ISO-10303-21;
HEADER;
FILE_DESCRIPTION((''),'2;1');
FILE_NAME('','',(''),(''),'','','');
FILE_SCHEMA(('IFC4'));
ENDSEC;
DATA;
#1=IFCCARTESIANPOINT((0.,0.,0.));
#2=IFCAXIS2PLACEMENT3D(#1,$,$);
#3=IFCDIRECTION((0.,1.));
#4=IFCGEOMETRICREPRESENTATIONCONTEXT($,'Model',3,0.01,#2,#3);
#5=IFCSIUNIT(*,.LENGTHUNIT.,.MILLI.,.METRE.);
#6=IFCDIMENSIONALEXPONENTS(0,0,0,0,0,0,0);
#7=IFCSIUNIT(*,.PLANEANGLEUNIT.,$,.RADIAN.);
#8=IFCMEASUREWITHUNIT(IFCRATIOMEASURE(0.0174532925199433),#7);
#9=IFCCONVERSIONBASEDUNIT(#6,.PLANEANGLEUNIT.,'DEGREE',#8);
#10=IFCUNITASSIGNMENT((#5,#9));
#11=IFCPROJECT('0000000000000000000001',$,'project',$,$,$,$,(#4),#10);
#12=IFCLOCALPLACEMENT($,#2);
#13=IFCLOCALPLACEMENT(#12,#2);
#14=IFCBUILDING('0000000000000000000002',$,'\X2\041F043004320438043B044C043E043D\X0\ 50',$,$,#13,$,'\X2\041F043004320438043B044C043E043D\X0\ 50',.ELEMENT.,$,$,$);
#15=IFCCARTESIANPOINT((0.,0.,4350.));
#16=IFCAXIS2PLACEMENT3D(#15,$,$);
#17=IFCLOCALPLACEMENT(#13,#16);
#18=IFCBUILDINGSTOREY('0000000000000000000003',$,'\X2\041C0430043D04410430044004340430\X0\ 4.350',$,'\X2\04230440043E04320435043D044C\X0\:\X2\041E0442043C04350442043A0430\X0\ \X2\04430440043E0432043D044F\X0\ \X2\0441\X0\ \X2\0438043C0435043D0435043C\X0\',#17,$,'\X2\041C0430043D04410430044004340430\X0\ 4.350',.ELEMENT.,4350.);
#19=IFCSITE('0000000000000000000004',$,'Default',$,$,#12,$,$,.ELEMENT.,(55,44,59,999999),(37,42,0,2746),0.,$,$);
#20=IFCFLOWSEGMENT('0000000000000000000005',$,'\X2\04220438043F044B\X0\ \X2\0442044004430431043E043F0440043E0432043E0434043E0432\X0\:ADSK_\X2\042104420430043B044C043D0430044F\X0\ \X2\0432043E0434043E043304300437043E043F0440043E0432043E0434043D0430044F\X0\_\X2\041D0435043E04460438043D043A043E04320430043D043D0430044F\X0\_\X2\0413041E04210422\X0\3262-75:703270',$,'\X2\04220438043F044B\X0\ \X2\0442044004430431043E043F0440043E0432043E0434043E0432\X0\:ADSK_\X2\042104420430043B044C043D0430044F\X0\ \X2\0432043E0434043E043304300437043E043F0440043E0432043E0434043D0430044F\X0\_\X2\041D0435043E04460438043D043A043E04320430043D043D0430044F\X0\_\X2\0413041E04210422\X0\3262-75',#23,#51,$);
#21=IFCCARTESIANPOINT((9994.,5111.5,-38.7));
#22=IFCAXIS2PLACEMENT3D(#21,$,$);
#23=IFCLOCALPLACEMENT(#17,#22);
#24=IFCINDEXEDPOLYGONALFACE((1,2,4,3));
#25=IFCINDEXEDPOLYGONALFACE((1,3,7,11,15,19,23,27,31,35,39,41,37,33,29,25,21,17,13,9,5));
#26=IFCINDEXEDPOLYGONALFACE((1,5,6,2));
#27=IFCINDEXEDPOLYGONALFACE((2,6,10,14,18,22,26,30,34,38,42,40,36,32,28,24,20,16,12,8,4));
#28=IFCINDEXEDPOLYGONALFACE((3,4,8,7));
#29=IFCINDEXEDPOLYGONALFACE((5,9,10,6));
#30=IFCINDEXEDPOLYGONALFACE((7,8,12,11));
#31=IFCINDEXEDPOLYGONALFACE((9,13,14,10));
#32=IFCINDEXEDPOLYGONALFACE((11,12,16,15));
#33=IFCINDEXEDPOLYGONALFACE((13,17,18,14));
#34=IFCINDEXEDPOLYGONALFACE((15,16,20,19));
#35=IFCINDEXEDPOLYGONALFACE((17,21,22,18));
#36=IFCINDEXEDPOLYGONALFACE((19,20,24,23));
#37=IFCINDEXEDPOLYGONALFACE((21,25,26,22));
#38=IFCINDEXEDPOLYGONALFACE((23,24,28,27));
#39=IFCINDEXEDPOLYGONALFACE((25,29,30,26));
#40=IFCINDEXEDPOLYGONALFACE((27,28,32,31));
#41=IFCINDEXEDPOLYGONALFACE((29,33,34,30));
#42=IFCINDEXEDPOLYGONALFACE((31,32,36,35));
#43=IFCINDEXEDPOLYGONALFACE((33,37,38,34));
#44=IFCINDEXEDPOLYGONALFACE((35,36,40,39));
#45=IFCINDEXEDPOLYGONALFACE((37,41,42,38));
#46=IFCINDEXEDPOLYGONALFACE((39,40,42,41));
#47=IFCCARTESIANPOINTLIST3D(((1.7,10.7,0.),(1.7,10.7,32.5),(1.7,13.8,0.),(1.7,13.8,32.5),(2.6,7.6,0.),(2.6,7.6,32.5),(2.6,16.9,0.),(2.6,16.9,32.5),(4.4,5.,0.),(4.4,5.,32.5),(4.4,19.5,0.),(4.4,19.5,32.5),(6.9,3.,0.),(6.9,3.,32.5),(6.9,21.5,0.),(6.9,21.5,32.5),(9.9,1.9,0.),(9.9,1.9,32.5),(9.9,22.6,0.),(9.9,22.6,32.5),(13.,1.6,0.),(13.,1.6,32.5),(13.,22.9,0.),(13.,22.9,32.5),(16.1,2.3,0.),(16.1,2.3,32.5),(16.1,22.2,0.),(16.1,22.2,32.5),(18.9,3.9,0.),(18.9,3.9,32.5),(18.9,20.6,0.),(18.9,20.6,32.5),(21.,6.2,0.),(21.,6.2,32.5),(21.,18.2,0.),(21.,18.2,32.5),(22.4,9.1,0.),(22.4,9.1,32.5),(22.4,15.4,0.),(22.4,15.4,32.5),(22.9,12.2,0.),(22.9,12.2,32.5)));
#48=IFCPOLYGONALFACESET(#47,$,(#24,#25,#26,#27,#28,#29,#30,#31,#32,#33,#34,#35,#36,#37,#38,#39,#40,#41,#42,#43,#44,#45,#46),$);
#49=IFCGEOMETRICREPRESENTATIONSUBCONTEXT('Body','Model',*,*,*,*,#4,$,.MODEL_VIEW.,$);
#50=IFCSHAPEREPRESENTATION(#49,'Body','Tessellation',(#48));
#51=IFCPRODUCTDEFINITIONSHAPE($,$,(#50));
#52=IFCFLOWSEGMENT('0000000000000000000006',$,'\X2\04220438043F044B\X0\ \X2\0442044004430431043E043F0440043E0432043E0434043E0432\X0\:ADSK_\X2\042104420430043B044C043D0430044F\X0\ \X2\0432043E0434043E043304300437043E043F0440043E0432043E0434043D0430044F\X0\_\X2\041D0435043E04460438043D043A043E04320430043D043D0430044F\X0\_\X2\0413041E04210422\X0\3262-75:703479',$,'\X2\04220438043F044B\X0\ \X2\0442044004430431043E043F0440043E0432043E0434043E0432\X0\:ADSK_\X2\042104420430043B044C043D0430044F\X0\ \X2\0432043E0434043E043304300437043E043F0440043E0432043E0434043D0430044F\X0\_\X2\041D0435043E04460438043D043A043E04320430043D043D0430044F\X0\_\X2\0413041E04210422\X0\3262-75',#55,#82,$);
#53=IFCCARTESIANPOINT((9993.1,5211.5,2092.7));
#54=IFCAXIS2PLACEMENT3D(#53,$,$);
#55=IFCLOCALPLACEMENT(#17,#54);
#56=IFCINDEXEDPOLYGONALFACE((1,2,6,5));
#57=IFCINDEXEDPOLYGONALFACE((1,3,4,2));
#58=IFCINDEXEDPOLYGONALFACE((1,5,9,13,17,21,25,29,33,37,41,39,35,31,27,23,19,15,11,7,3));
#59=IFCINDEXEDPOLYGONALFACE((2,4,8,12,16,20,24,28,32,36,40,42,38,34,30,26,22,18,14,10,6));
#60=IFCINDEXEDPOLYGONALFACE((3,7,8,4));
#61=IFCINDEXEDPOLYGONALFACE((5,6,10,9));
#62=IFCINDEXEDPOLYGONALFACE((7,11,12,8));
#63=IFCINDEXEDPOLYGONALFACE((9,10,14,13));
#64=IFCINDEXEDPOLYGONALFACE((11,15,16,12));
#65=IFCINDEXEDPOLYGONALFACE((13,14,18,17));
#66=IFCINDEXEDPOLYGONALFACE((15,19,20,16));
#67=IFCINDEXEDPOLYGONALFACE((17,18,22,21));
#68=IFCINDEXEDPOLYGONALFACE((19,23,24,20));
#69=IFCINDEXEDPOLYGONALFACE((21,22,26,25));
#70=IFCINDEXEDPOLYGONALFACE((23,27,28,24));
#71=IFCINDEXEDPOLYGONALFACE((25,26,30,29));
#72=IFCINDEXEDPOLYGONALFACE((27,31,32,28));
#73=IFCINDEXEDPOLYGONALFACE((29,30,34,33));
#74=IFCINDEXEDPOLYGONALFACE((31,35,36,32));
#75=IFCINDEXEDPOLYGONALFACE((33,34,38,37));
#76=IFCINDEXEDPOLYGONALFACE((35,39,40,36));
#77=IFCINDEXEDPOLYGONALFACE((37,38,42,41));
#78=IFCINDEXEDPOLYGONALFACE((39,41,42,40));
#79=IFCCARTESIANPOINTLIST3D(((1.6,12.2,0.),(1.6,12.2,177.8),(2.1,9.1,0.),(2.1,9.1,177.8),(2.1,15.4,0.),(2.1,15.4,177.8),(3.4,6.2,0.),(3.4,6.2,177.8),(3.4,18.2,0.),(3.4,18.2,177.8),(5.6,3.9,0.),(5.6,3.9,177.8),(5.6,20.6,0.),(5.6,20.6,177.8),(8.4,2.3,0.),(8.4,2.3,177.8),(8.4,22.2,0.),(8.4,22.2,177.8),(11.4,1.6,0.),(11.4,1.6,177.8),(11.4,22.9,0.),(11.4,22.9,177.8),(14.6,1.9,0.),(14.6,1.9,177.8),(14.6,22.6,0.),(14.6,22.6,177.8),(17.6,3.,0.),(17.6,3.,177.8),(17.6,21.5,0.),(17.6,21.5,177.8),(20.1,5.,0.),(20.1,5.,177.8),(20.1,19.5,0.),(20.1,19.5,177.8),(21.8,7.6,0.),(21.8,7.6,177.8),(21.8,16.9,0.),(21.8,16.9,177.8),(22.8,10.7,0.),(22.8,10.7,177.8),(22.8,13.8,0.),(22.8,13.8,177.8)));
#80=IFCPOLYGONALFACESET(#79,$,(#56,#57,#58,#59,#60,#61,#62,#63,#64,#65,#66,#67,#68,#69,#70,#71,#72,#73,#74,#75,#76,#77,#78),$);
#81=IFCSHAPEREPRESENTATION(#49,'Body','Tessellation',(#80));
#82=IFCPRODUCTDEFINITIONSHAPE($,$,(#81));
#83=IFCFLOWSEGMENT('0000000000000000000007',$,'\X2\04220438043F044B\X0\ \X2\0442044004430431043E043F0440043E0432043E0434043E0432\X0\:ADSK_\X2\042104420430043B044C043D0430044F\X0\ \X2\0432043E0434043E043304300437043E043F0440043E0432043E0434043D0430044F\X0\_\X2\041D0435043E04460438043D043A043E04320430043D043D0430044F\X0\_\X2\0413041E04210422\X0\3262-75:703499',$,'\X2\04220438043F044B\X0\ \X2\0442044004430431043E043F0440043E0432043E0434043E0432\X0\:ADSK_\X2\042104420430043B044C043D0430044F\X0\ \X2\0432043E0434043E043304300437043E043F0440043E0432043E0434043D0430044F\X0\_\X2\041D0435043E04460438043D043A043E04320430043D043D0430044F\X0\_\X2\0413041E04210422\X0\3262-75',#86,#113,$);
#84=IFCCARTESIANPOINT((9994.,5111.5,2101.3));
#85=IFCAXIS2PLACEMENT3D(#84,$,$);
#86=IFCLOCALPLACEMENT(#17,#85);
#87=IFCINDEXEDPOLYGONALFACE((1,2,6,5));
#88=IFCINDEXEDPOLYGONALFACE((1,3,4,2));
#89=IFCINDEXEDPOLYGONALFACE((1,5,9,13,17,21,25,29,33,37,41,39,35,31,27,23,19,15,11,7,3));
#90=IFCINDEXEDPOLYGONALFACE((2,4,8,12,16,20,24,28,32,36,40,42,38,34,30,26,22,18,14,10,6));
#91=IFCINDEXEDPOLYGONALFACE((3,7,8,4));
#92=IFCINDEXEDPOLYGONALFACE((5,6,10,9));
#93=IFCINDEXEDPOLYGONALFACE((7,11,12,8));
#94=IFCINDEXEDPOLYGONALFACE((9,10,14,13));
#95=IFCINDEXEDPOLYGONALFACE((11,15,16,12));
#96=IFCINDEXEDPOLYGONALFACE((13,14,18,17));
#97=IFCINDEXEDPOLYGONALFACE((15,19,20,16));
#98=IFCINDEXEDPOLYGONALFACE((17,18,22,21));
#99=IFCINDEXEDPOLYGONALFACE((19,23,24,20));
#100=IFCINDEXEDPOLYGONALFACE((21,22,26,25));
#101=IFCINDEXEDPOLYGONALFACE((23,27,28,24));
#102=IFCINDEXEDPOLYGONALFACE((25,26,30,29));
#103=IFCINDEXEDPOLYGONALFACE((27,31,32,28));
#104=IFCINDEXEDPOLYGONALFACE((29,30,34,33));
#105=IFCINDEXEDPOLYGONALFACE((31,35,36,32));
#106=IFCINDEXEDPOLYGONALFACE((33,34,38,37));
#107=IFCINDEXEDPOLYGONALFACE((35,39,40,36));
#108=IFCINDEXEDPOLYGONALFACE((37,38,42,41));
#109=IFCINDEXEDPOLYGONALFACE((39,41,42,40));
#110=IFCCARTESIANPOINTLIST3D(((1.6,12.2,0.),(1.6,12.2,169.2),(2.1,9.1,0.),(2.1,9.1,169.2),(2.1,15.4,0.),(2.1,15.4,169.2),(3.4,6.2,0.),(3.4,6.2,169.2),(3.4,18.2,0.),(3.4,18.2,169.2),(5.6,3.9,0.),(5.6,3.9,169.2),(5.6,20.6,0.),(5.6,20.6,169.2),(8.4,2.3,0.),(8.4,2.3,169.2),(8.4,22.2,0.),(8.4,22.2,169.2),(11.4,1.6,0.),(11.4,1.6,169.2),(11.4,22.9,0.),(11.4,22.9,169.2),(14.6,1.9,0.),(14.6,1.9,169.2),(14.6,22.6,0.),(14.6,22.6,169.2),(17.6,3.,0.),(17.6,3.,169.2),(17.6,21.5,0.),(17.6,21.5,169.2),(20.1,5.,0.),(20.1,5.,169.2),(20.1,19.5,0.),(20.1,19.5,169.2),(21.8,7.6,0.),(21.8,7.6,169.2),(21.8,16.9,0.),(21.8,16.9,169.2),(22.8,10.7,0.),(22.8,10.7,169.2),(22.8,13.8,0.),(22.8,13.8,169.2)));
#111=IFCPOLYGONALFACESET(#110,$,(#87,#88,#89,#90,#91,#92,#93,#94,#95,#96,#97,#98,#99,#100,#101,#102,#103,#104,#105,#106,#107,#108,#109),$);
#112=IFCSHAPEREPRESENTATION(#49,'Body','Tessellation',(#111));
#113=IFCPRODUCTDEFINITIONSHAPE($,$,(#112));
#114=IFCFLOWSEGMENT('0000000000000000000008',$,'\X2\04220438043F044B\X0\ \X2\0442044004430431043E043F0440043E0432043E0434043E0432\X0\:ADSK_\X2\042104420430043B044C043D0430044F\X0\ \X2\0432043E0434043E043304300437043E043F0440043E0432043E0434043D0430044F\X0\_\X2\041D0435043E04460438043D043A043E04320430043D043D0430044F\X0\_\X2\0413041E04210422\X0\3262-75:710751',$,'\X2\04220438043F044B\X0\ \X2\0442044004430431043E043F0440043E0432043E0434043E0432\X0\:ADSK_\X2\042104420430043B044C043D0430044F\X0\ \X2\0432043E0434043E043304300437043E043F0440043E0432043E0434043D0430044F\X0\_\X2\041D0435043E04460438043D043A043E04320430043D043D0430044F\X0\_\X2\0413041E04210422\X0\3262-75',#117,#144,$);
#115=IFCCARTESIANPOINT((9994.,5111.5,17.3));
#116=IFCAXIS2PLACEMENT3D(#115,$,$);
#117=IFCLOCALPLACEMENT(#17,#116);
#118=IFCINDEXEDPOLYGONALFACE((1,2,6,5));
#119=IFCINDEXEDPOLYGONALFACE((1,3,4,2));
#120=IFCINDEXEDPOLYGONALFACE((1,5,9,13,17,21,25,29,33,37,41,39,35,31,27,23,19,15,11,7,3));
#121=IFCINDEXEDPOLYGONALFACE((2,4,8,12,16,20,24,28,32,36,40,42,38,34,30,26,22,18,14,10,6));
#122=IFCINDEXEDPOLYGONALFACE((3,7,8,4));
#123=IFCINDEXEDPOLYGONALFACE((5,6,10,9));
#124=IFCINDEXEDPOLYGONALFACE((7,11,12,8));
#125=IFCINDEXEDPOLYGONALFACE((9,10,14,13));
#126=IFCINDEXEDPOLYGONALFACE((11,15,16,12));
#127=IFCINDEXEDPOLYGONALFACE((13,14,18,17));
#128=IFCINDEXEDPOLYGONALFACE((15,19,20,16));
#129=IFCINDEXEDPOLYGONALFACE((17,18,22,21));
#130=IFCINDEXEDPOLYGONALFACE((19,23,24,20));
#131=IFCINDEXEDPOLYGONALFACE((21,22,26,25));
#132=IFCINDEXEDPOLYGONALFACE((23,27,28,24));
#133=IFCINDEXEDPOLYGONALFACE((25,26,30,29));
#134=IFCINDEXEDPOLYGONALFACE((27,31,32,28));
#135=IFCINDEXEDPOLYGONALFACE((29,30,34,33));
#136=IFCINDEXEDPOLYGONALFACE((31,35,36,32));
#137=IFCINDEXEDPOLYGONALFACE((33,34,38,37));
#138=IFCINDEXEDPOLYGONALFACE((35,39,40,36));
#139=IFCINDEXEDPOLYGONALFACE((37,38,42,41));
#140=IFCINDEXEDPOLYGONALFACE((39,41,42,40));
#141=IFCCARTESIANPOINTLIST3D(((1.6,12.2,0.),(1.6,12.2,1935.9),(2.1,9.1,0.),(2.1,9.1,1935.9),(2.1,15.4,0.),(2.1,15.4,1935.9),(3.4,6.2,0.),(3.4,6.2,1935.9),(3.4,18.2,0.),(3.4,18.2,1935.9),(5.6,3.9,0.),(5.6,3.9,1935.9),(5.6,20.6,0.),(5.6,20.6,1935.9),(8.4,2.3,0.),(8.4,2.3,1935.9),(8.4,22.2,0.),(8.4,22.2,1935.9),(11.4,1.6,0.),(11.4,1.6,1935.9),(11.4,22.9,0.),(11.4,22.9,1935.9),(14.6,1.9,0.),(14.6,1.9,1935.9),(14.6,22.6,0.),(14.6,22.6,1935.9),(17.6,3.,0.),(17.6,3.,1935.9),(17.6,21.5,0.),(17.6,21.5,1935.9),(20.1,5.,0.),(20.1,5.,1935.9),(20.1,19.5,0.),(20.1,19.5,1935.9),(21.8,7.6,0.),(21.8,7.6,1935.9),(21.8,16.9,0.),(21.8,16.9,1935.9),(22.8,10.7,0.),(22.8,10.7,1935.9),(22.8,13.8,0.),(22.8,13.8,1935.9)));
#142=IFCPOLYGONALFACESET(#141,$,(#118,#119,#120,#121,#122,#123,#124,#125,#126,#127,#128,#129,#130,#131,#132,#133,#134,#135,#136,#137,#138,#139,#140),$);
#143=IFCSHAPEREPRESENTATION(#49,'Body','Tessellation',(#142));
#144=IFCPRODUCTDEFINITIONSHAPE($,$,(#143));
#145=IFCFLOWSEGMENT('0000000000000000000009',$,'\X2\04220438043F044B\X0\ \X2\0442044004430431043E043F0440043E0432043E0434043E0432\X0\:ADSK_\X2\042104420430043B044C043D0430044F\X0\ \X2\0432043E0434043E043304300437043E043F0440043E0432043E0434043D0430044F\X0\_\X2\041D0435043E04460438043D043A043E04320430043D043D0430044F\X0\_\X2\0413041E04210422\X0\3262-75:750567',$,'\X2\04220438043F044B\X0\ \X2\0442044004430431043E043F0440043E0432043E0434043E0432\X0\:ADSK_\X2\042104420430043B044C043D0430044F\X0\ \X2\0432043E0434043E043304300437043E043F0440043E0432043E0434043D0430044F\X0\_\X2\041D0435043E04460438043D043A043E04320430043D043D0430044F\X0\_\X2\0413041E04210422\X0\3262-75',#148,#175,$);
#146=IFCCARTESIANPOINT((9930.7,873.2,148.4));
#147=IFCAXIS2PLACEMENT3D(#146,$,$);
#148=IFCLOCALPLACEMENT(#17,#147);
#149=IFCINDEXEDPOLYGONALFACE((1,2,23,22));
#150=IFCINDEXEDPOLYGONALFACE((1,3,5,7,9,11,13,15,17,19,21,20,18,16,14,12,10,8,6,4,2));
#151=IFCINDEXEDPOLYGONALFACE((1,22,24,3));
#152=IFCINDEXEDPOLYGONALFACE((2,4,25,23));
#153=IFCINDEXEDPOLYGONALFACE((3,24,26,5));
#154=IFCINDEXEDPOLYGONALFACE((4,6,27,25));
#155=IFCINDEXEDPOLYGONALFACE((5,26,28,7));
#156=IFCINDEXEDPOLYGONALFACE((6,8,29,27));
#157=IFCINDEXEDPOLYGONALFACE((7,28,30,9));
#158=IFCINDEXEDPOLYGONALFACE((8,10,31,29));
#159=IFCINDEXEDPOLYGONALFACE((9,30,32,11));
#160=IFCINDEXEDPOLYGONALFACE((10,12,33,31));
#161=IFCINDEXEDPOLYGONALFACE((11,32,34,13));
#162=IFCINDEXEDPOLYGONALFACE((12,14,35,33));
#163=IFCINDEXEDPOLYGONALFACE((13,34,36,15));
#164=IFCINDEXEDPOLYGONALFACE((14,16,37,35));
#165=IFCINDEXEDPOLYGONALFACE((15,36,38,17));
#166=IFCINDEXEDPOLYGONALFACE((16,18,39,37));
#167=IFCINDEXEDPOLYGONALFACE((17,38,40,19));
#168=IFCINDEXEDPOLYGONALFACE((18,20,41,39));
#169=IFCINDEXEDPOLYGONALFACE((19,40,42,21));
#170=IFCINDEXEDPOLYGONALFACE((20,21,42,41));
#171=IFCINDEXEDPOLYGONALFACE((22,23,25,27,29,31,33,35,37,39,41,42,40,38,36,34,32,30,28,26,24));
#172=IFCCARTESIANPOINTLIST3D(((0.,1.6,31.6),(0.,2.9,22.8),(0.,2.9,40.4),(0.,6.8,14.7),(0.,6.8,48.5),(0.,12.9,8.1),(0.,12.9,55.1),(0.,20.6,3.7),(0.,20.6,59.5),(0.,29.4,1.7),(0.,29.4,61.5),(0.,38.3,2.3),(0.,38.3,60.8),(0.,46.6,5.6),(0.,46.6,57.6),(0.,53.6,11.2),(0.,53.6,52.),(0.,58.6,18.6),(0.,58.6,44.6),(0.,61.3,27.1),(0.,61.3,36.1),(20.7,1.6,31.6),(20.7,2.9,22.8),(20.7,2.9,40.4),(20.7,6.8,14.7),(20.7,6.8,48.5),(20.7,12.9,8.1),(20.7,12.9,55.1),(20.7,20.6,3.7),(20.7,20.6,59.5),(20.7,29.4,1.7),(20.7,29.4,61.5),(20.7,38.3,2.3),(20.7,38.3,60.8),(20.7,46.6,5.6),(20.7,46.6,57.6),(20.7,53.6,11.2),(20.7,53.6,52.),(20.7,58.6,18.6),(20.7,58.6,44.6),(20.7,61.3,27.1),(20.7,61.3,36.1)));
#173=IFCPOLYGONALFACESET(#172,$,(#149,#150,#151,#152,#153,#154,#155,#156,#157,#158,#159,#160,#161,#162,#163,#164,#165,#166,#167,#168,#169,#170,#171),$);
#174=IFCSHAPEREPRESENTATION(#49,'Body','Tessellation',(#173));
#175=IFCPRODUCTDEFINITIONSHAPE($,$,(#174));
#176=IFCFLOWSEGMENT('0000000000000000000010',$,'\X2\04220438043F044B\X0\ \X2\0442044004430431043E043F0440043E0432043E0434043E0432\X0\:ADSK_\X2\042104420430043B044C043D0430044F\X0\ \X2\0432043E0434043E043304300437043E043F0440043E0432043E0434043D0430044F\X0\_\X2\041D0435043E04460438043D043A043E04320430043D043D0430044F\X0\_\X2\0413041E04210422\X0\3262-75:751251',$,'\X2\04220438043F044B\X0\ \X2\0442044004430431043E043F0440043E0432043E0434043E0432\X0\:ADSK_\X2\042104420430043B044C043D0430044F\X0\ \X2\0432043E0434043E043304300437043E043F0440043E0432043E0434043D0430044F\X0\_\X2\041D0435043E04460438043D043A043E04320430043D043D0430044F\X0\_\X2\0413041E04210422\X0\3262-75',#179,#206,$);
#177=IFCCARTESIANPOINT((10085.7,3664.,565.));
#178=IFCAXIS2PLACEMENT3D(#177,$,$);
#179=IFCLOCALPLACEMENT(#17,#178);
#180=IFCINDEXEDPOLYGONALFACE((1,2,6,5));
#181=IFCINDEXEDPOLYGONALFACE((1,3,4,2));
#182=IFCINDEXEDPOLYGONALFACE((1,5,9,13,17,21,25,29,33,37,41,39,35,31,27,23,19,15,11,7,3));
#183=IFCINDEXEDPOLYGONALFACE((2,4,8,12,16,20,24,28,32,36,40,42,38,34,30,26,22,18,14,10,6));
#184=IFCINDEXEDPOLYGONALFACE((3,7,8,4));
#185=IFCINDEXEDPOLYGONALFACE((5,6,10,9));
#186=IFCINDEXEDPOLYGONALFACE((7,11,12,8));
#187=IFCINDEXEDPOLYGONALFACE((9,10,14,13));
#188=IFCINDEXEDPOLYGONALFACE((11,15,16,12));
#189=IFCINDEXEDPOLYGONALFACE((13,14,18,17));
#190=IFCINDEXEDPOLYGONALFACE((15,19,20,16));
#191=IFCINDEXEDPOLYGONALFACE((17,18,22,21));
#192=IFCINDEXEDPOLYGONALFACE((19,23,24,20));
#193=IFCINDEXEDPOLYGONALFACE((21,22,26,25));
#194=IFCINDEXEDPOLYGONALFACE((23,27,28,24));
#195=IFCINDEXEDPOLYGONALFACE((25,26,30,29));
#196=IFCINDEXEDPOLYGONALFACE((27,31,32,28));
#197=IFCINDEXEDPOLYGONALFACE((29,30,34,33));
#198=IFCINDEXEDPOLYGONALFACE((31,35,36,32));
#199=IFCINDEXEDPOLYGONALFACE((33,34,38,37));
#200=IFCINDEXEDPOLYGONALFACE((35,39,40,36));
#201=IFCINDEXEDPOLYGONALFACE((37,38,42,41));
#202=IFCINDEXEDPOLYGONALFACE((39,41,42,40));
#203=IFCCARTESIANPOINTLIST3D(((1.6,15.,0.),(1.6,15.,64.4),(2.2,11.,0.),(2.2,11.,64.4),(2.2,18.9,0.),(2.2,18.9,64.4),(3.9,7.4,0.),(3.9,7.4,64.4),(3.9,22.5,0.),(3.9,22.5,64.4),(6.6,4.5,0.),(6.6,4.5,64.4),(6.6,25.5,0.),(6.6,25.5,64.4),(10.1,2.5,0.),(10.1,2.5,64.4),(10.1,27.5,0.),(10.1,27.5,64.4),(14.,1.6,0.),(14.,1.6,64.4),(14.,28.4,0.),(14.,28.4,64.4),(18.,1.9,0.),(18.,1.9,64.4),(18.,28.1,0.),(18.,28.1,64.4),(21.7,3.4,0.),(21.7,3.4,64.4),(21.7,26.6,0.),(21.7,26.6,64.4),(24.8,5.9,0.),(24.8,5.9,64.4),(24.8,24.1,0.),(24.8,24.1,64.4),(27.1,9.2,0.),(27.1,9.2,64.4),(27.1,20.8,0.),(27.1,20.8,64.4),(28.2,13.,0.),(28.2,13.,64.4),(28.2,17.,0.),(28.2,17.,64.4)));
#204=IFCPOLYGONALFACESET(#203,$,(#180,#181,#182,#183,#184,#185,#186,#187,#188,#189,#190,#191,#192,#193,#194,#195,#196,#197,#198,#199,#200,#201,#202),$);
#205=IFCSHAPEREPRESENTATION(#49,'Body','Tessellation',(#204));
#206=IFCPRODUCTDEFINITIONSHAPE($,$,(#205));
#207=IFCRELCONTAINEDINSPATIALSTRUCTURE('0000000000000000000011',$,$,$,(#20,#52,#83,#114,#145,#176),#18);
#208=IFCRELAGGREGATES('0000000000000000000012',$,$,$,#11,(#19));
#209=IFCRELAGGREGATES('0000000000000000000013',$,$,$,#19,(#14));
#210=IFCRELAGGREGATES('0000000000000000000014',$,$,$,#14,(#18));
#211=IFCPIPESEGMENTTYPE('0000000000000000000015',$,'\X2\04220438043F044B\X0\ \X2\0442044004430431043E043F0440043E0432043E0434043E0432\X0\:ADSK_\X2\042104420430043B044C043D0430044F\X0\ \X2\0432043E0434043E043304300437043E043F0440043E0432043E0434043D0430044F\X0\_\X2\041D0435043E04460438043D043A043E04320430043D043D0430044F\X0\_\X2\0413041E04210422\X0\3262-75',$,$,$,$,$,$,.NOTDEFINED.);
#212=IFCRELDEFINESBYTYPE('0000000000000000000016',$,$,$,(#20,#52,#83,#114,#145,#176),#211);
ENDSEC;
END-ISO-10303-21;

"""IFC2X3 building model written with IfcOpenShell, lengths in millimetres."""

from ifc_helpers import new_model, entity, si_unit, converted_unit, direction, frame, frame_2d, origin, origin_2d_with_axis, place, context, subcontext, project, spatial, circle, extrude, type_object, element, save


model = new_model("IFC2X3")

# Units and contexts
model_context = context("Model", 3, precision=0.01, world=origin(), true_north=direction((0.0, 1.0)))
body_context = subcontext(model_context, "Body", "Model", "MODEL_VIEW")
ifc_project = project(units=[si_unit("LENGTHUNIT", "METRE", prefix="MILLI"), converted_unit("PLANEANGLEUNIT", "DEGREE", entity("IfcRatioMeasure", 0.0174532925199433), si_unit("PLANEANGLEUNIT", "RADIAN"), dimensions=[0, 0, 0, 0, 0, 0, 0])], contexts=[model_context])

# Site, building, storey
site_placement = place(None, origin())
site = spatial("IfcSite", under=ifc_project, at=site_placement, Name="Default", CompositionType="ELEMENT", RefLatitude=(55, 44, 59, 999999), RefLongitude=(37, 42, 0, 2746), RefElevation=0.0)
building_placement = place(site_placement, origin())
building = spatial("IfcBuilding", under=site, at=building_placement, Name="Павильон 50", LongName="Павильон 50", CompositionType="ELEMENT")
storey_placement = place(building_placement, frame((0.0, 0.0, 4350.0)))
storey = spatial("IfcBuildingStorey", under=building, at=storey_placement, Name="Мансарда 4.350", ObjectType="Уровень:Отметка уровня с именем", LongName="Мансарда 4.350", CompositionType="ELEMENT", Elevation=4350.0)

# Flow segments
pipe_segment_type = type_object("IfcPipeSegmentType", Name="Типы трубопроводов:ADSK_Стальная водогазопроводная_Неоцинкованная_ГОСТ3262-75", PredefinedType="NOTDEFINED")
flow_segment_1_placement = place(storey_placement, frame((9994.0, 5111.5, -38.7)))
element("IfcFlowSegment", 1, at=flow_segment_1_placement, inside=storey, type_object=pipe_segment_type, Name="Типы трубопроводов:ADSK_Стальная водогазопроводная_Неоцинкованная_ГОСТ3262-75:703270", ObjectType="Типы трубопроводов:ADSK_Стальная водогазопроводная_Неоцинкованная_ГОСТ3262-75", context=body_context, shape_type="SweptSolid", body=[
    extrude(circle(Radius=10.7, at=origin_2d_with_axis()), frame((12.2, 12.2, 0.0)), (0.0, 0.0, 1.0), 32.5),
])
flow_segment_2_placement = place(storey_placement, frame((9993.1, 5211.5, 2092.7)))
element("IfcFlowSegment", 2, at=flow_segment_2_placement, inside=storey, type_object=pipe_segment_type, Name="Типы трубопроводов:ADSK_Стальная водогазопроводная_Неоцинкованная_ГОСТ3262-75:703479", ObjectType="Типы трубопроводов:ADSK_Стальная водогазопроводная_Неоцинкованная_ГОСТ3262-75", context=body_context, shape_type="SweptSolid", body=[
    extrude(circle(Radius=10.7, at=origin_2d_with_axis()), frame((12.2, 12.2, 0.0), z_axis=(0.0, 0.0, 1.0), x_axis=(-1.0, 0.0, 0.0)), (0.0, 0.0, 1.0), 177.8),
])
flow_segment_3_placement = place(storey_placement, frame((9994.0, 5111.5, 2101.3)))
element("IfcFlowSegment", 3, at=flow_segment_3_placement, inside=storey, type_object=pipe_segment_type, Name="Типы трубопроводов:ADSK_Стальная водогазопроводная_Неоцинкованная_ГОСТ3262-75:703499", ObjectType="Типы трубопроводов:ADSK_Стальная водогазопроводная_Неоцинкованная_ГОСТ3262-75", context=body_context, shape_type="SweptSolid", body=[
    extrude(circle(Radius=10.7, at=origin_2d_with_axis()), frame((12.2, 12.2, 0.0), z_axis=(0.0, 0.0, 1.0), x_axis=(-1.0, 0.0, 0.0)), (0.0, 0.0, 1.0), 169.2),
])
flow_segment_4_placement = place(storey_placement, frame((9994.0, 5111.5, 17.3)))
element("IfcFlowSegment", 4, at=flow_segment_4_placement, inside=storey, type_object=pipe_segment_type, Name="Типы трубопроводов:ADSK_Стальная водогазопроводная_Неоцинкованная_ГОСТ3262-75:710751", ObjectType="Типы трубопроводов:ADSK_Стальная водогазопроводная_Неоцинкованная_ГОСТ3262-75", context=body_context, shape_type="SweptSolid", body=[
    extrude(circle(Radius=10.7, at=origin_2d_with_axis()), frame((12.2, 12.2, 0.0), z_axis=(0.0, 0.0, 1.0), x_axis=(-1.0, 0.0, 0.0)), (0.0, 0.0, 1.0), 1935.9),
])
flow_segment_5_placement = place(storey_placement, frame((9930.7, 873.2, 148.4)))
element("IfcFlowSegment", 5, at=flow_segment_5_placement, inside=storey, type_object=pipe_segment_type, Name="Типы трубопроводов:ADSK_Стальная водогазопроводная_Неоцинкованная_ГОСТ3262-75:750567", ObjectType="Типы трубопроводов:ADSK_Стальная водогазопроводная_Неоцинкованная_ГОСТ3262-75", context=body_context, shape_type="SweptSolid", body=[
    extrude(circle(Radius=30.0, at=frame_2d((0.0, 0.0), x_axis=(1.0, 0.0))), frame((0.0, 31.6, 31.6), z_axis=(1.0, 0.0, 0.0), x_axis=(0.0, -1.0, 0.0)), (0.0, 0.0, 1.0), 20.7),
])
flow_segment_6_placement = place(storey_placement, frame((10085.7, 3664.0, 565.0)))
element("IfcFlowSegment", 6, at=flow_segment_6_placement, inside=storey, type_object=pipe_segment_type, Name="Типы трубопроводов:ADSK_Стальная водогазопроводная_Неоцинкованная_ГОСТ3262-75:751251", ObjectType="Типы трубопроводов:ADSK_Стальная водогазопроводная_Неоцинкованная_ГОСТ3262-75", context=body_context, shape_type="SweptSolid", body=[
    extrude(circle(Radius=13.4, at=origin_2d_with_axis()), frame((15.0, 15.0, 0.0), z_axis=(0.0, 0.0, 1.0), x_axis=(-1.0, 0.0, 0.0)), (0.0, 0.0, 1.0), 64.4),
])

save(model, "model.ifc")
